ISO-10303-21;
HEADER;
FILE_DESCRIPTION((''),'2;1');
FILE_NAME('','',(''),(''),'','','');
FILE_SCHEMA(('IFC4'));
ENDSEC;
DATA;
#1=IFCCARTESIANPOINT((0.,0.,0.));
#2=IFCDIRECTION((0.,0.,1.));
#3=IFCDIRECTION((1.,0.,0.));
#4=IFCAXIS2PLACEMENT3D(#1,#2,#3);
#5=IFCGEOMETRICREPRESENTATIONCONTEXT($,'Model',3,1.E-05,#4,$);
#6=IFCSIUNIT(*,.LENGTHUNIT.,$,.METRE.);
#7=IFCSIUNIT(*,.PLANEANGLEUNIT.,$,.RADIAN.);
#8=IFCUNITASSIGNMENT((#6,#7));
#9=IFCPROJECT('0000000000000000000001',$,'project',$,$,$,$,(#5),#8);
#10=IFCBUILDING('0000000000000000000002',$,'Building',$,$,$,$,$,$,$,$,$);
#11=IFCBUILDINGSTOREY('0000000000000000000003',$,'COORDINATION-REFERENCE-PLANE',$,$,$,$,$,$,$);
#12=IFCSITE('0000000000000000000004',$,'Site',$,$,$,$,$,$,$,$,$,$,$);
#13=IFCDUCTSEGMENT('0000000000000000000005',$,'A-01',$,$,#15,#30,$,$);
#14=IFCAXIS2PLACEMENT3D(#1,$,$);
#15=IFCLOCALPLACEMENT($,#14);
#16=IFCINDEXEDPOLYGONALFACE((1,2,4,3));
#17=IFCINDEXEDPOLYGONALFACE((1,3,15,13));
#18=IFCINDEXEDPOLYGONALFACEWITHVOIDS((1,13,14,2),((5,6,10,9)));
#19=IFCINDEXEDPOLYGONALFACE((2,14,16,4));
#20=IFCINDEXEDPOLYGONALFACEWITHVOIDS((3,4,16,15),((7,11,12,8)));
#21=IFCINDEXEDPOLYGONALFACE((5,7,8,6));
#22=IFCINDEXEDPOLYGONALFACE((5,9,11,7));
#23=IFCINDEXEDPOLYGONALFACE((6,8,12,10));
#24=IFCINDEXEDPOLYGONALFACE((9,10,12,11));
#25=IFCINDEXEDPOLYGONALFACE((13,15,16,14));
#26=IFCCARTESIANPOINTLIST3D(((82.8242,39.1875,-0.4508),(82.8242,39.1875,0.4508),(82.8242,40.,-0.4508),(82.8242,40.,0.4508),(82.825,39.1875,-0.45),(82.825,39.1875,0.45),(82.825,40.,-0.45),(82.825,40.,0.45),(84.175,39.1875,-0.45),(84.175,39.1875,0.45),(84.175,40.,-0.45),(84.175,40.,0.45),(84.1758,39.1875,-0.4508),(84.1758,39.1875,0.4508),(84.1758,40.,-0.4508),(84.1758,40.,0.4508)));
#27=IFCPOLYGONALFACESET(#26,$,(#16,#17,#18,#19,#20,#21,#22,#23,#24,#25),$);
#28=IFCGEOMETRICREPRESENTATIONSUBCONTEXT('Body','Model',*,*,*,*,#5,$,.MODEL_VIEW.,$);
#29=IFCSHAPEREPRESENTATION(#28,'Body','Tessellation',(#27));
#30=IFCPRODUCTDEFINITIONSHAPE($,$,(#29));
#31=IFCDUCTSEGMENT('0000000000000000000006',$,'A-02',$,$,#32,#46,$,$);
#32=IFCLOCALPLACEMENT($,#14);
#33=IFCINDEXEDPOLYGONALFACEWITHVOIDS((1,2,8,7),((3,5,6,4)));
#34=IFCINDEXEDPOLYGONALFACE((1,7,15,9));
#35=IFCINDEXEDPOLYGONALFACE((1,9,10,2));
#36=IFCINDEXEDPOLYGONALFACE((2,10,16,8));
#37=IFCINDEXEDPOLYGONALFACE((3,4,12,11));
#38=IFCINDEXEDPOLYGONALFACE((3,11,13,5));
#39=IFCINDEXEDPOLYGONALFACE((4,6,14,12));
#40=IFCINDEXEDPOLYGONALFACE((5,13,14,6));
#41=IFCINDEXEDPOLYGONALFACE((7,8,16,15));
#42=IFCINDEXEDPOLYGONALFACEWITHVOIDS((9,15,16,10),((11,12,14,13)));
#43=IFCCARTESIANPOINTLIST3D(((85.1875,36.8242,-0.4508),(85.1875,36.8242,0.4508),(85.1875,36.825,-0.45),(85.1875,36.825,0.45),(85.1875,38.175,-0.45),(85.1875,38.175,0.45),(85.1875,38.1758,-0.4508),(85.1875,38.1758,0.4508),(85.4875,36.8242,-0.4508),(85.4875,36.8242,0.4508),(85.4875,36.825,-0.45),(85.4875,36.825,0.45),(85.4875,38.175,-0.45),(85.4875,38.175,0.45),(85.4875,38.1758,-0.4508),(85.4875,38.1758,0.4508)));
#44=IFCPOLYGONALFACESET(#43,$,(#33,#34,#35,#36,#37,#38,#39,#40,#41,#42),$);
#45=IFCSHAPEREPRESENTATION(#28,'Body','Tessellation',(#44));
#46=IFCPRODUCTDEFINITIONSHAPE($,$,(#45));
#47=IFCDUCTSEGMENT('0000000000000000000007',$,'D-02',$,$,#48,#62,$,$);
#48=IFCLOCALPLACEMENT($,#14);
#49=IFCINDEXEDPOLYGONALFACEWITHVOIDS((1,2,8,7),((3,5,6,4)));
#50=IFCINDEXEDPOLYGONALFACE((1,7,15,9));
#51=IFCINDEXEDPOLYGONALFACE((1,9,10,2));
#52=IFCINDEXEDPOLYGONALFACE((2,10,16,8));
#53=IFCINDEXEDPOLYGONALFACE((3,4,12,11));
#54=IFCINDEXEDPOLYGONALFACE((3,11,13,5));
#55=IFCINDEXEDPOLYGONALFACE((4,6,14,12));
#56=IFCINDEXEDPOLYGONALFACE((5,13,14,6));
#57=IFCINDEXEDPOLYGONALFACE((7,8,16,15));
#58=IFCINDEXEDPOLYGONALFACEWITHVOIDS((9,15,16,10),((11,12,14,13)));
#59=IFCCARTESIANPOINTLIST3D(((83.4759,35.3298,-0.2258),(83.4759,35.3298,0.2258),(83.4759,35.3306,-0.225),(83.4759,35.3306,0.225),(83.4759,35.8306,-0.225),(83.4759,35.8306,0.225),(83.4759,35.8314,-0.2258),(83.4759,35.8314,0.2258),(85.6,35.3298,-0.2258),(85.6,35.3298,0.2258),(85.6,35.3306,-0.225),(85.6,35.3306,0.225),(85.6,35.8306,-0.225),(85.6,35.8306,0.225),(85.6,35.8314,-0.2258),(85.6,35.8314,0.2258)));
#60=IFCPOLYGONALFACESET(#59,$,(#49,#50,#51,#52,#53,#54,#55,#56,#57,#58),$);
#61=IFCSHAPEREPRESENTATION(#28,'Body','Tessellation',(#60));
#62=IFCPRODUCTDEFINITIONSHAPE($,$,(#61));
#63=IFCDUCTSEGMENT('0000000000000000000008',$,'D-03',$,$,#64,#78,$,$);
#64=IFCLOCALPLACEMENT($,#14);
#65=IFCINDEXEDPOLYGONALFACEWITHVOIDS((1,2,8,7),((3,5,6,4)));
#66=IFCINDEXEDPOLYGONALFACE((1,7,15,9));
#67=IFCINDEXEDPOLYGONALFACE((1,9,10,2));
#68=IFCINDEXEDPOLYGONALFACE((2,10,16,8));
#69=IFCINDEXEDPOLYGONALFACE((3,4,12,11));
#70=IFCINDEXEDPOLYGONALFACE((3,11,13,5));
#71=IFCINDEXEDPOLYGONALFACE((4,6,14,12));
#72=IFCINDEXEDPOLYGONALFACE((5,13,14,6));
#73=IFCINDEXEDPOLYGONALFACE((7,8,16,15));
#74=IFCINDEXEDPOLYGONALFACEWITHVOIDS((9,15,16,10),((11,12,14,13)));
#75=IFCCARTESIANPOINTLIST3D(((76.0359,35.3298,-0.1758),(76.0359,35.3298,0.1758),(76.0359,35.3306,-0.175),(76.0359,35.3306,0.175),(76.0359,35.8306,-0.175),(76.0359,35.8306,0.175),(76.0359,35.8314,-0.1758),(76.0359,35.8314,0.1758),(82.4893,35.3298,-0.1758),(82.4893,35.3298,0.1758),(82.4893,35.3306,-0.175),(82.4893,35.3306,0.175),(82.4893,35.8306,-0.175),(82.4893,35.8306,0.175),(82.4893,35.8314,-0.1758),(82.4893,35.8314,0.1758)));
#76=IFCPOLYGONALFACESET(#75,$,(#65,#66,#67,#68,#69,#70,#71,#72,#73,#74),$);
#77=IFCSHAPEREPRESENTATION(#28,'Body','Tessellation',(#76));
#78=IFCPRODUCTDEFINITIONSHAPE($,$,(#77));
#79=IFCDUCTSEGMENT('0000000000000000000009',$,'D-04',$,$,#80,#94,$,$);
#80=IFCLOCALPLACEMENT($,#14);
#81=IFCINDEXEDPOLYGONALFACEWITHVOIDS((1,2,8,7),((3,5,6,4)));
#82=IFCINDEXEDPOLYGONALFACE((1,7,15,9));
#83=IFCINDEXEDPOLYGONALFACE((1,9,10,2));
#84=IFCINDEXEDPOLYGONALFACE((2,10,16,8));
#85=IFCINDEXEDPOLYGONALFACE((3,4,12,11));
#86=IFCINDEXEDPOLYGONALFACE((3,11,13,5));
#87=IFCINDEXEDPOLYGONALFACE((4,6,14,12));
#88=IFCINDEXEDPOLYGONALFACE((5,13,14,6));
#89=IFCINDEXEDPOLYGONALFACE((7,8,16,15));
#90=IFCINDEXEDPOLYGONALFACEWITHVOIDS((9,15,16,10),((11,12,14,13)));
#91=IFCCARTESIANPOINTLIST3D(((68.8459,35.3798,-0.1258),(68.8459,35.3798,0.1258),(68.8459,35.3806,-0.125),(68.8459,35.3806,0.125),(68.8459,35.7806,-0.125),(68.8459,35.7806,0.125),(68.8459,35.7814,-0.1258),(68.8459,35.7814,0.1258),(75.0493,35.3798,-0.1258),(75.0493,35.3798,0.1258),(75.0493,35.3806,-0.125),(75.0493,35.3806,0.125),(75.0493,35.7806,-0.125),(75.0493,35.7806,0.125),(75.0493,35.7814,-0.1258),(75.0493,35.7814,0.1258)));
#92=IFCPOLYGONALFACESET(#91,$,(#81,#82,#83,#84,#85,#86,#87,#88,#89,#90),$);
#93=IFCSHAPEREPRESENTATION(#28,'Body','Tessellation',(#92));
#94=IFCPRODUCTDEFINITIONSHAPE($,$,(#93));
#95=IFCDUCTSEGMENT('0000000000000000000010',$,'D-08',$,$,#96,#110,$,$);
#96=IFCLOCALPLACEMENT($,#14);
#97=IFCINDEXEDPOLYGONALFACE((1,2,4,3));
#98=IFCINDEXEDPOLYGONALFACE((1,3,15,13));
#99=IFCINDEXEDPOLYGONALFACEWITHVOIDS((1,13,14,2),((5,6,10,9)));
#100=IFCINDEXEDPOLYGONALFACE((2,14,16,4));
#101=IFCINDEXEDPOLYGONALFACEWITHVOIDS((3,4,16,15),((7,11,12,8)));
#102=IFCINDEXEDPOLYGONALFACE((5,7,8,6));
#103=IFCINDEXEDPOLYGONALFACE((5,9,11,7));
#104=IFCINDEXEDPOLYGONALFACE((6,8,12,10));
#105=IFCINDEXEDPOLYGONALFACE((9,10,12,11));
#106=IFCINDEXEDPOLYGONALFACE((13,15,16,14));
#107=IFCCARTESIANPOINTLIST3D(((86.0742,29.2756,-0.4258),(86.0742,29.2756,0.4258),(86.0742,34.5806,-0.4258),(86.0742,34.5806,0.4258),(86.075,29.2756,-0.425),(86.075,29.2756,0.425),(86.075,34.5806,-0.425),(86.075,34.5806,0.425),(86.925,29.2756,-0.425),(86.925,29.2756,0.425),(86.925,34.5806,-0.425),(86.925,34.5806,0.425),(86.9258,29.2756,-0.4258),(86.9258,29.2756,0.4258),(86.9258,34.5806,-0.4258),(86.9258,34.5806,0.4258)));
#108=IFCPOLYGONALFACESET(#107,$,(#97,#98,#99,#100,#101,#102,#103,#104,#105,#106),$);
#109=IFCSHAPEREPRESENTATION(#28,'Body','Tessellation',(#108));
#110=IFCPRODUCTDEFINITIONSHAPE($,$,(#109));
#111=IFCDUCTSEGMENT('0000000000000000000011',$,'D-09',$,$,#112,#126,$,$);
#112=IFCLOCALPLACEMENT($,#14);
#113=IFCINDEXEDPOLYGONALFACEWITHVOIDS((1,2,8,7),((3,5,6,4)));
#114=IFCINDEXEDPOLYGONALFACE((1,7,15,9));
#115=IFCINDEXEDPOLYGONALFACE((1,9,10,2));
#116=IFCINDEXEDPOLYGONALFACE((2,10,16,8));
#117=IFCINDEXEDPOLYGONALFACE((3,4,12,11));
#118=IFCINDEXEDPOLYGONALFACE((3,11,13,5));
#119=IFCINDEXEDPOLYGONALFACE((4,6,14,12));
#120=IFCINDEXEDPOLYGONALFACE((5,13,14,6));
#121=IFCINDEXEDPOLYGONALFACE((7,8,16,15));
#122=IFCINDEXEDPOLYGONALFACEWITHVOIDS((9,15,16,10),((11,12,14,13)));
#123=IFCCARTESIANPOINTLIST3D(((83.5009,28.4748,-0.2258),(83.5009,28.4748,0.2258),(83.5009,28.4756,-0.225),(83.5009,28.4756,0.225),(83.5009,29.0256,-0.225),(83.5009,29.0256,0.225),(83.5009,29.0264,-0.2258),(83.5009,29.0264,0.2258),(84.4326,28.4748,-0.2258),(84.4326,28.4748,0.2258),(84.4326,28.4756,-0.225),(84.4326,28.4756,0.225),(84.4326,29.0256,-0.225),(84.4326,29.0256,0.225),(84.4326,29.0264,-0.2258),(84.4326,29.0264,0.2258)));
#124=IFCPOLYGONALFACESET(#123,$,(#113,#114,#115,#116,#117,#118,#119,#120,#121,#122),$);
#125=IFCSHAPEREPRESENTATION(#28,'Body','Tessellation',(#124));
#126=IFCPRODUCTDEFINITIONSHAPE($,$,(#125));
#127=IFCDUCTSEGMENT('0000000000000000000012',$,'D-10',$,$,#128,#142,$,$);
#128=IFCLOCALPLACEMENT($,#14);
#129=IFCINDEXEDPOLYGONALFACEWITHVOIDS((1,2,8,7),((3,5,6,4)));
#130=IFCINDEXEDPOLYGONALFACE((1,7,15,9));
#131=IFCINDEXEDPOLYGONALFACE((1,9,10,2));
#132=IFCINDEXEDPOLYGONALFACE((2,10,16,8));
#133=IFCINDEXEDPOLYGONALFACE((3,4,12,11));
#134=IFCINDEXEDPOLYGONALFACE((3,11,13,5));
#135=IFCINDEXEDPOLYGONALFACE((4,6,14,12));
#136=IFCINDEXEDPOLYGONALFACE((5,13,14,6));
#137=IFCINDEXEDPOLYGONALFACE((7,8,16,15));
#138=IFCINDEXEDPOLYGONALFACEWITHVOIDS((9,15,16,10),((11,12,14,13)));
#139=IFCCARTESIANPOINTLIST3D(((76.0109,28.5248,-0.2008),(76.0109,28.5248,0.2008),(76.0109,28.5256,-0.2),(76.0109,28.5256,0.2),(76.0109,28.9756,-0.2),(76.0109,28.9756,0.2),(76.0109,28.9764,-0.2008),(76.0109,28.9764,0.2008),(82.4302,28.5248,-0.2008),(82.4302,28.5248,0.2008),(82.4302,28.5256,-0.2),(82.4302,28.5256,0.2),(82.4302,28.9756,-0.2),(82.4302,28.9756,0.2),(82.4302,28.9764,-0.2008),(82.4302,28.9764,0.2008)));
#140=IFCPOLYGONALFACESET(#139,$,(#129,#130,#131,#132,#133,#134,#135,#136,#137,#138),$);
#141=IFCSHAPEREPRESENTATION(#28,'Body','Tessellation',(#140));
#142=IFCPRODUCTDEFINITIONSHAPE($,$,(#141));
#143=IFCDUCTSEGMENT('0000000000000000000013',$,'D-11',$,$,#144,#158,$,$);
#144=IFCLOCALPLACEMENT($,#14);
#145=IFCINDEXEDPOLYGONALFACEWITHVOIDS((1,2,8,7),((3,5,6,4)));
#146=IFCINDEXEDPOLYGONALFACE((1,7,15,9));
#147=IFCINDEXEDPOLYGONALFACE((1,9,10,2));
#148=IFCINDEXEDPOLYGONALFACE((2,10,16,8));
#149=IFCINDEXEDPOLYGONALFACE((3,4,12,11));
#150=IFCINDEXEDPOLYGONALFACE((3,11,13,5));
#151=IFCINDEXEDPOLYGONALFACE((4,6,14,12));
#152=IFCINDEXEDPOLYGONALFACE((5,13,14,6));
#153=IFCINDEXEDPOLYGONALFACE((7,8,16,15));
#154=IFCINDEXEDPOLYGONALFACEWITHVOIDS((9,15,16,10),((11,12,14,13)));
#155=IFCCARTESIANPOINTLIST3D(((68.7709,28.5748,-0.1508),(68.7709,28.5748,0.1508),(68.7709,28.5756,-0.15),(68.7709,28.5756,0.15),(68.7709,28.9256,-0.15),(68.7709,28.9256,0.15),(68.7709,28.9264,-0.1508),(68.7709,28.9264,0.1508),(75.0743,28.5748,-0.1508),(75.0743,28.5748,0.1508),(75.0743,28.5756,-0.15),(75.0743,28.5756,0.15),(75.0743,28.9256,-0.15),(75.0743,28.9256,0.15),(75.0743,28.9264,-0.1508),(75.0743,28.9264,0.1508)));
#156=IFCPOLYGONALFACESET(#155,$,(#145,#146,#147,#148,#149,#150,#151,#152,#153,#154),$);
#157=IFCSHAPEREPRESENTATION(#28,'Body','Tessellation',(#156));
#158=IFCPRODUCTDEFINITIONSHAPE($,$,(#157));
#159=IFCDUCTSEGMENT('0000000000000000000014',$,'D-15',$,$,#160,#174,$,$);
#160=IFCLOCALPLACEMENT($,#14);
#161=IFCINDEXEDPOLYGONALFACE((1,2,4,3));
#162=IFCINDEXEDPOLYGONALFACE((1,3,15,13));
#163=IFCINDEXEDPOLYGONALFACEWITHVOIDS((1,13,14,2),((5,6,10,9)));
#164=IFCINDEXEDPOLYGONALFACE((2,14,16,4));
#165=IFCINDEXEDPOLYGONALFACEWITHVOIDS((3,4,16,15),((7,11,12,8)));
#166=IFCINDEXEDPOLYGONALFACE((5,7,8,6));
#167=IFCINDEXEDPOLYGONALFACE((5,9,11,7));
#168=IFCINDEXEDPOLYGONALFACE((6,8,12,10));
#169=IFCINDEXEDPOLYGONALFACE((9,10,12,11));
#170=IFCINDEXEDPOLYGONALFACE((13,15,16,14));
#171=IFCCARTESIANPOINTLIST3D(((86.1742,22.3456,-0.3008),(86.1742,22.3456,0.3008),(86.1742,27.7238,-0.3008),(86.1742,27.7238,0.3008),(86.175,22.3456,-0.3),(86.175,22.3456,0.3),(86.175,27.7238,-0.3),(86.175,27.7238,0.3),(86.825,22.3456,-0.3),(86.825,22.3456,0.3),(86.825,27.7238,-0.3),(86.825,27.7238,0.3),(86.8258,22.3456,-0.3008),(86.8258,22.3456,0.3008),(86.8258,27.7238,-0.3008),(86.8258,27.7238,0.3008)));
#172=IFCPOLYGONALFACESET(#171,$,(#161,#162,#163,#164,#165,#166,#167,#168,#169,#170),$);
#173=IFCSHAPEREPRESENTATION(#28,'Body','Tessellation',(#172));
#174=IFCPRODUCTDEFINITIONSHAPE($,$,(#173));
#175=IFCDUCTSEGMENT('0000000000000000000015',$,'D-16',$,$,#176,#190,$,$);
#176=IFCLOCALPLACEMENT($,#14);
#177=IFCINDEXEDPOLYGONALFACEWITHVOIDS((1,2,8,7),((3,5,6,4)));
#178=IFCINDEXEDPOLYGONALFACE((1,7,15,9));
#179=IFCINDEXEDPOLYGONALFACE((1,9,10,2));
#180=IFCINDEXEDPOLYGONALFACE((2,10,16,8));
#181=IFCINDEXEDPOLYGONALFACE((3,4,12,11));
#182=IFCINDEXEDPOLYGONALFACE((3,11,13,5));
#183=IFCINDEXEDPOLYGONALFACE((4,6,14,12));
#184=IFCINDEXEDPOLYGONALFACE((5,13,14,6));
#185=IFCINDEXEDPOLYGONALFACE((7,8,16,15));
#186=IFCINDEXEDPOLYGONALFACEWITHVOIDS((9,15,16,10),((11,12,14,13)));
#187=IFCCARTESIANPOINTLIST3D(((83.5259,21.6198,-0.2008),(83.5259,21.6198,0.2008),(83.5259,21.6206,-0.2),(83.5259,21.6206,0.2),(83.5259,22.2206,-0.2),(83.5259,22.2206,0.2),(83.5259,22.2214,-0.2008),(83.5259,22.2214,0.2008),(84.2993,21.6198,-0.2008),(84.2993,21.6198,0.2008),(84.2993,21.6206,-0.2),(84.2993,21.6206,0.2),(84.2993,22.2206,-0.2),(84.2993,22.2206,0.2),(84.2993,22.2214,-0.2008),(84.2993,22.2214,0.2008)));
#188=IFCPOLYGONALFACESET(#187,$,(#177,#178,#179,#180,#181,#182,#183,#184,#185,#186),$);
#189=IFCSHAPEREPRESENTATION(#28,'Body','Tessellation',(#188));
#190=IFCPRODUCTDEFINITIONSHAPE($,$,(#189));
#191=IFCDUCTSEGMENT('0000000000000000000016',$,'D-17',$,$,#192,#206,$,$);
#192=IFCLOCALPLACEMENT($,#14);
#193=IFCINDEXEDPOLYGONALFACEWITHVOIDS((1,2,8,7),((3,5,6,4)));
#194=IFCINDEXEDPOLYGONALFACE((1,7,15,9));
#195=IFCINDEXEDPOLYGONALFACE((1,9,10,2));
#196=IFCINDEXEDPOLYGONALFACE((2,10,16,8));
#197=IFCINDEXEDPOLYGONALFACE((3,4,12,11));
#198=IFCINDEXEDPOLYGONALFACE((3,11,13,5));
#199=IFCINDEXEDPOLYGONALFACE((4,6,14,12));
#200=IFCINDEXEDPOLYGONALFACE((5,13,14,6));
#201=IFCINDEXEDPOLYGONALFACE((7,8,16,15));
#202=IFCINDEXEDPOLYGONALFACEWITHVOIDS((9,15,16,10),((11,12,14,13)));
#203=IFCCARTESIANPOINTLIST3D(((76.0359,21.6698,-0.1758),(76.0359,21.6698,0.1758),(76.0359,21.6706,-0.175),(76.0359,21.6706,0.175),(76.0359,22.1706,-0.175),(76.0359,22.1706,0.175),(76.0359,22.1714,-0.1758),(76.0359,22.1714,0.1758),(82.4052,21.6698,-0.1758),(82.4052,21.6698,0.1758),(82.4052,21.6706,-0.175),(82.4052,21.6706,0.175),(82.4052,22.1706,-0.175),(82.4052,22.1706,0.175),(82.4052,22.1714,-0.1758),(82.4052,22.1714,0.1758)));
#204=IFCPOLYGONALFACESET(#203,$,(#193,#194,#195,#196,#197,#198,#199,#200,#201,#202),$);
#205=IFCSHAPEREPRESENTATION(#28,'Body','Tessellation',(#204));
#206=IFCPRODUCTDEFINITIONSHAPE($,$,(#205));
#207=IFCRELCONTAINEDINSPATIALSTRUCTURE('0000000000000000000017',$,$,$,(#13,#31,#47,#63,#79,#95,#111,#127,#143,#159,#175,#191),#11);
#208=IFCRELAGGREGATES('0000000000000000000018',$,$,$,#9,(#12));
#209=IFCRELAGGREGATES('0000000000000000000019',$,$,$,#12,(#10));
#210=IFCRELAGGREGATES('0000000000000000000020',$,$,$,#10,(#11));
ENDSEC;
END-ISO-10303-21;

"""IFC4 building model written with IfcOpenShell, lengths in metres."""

from ifc_helpers import new_model, si_unit, frame, origin, origin_with_axes, place, context, subcontext, project, spatial, hollow_rectangle, extrude, element, save


model = new_model("IFC4")

# Units and contexts
model_context = context("Model", 3, precision=1e-05, world=origin_with_axes())
body_context = subcontext(model_context, "Body", "Model", "MODEL_VIEW")
ifc_project = project(units=[si_unit("LENGTHUNIT", "METRE"), si_unit("PLANEANGLEUNIT", "RADIAN")], contexts=[model_context])

# Site, building, storey
site = spatial("IfcSite", under=ifc_project, Name="Site")
building = spatial("IfcBuilding", under=site, Name="Building")
storey = spatial("IfcBuildingStorey", under=building, Name="COORDINATION-REFERENCE-PLANE")

# Duct segments
duct_segment_1_placement = place(None, frame((83.5, 39.1875, 0.0), z_axis=(0.0, 1.0, 0.0), x_axis=(1.0, 0.0, 0.0)))
element("IfcDuctSegment", 1, at=duct_segment_1_placement, inside=storey, Name="A-01", context=body_context, shape_type="SweptSolid", body=[
    extrude(hollow_rectangle(XDim=1.3516, YDim=0.9016, WallThickness=0.0008), origin(), (0.0, 0.0, 1.0), 0.8125),
])
duct_segment_2_placement = place(None, frame((85.1875, 37.5, 0.0), z_axis=(1.0, 0.0, 0.0), x_axis=(0.0, 1.0, 0.0)))
element("IfcDuctSegment", 2, at=duct_segment_2_placement, inside=storey, Name="A-02", context=body_context, shape_type="SweptSolid", body=[
    extrude(hollow_rectangle(XDim=1.3516, YDim=0.9016, WallThickness=0.0008), origin(), (0.0, 0.0, 1.0), 0.3),
])
duct_segment_3_placement = place(None, frame((83.4759, 35.5806, 0.0), z_axis=(1.0, 0.0, 0.0), x_axis=(0.0, 1.0, 0.0)))
element("IfcDuctSegment", 3, at=duct_segment_3_placement, inside=storey, Name="D-02", context=body_context, shape_type="SweptSolid", body=[
    extrude(hollow_rectangle(XDim=0.5016, YDim=0.4516, WallThickness=0.0008), origin(), (0.0, 0.0, 1.0), 2.1241),
])
duct_segment_4_placement = place(None, frame((76.0359, 35.5806, 0.0), z_axis=(1.0, 0.0, 0.0), x_axis=(0.0, 1.0, 0.0)))
element("IfcDuctSegment", 4, at=duct_segment_4_placement, inside=storey, Name="D-03", context=body_context, shape_type="SweptSolid", body=[
    extrude(hollow_rectangle(XDim=0.5016, YDim=0.3516, WallThickness=0.0008), origin(), (0.0, 0.0, 1.0), 6.4534),
])
duct_segment_5_placement = place(None, frame((68.8459, 35.5806, 0.0), z_axis=(1.0, 0.0, 0.0), x_axis=(0.0, 1.0, 0.0)))
element("IfcDuctSegment", 5, at=duct_segment_5_placement, inside=storey, Name="D-04", context=body_context, shape_type="SweptSolid", body=[
    extrude(hollow_rectangle(XDim=0.4016, YDim=0.2516, WallThickness=0.0008), origin(), (0.0, 0.0, 1.0), 6.2034),
])
duct_segment_6_placement = place(None, frame((86.5, 29.2756, 0.0), z_axis=(0.0, 1.0, 0.0), x_axis=(1.0, 0.0, 0.0)))
element("IfcDuctSegment", 6, at=duct_segment_6_placement, inside=storey, Name="D-08", context=body_context, shape_type="SweptSolid", body=[
    extrude(hollow_rectangle(XDim=0.8516, YDim=0.8516, WallThickness=0.0008), origin(), (0.0, 0.0, 1.0), 5.305),
])
duct_segment_7_placement = place(None, frame((83.5009, 28.7506, 0.0), z_axis=(1.0, 0.0, 0.0), x_axis=(0.0, 1.0, 0.0)))
element("IfcDuctSegment", 7, at=duct_segment_7_placement, inside=storey, Name="D-09", context=body_context, shape_type="SweptSolid", body=[
    extrude(hollow_rectangle(XDim=0.5516, YDim=0.4516, WallThickness=0.0008), origin(), (0.0, 0.0, 1.0), 0.9316),
])
duct_segment_8_placement = place(None, frame((76.0109, 28.7506, 0.0), z_axis=(1.0, 0.0, 0.0), x_axis=(0.0, 1.0, 0.0)))
element("IfcDuctSegment", 8, at=duct_segment_8_placement, inside=storey, Name="D-10", context=body_context, shape_type="SweptSolid", body=[
    extrude(hollow_rectangle(XDim=0.4516, YDim=0.4016, WallThickness=0.0008), origin(), (0.0, 0.0, 1.0), 6.4193),
])
duct_segment_9_placement = place(None, frame((68.7709, 28.7506, 0.0), z_axis=(1.0, 0.0, 0.0), x_axis=(0.0, 1.0, 0.0)))
element("IfcDuctSegment", 9, at=duct_segment_9_placement, inside=storey, Name="D-11", context=body_context, shape_type="SweptSolid", body=[
    extrude(hollow_rectangle(XDim=0.3516, YDim=0.3016, WallThickness=0.0008), origin(), (0.0, 0.0, 1.0), 6.3034),
])
duct_segment_10_placement = place(None, frame((86.5, 22.3456, 0.0), z_axis=(0.0, 1.0, 0.0), x_axis=(1.0, 0.0, 0.0)))
element("IfcDuctSegment", 10, at=duct_segment_10_placement, inside=storey, Name="D-15", context=body_context, shape_type="SweptSolid", body=[
    extrude(hollow_rectangle(XDim=0.6516, YDim=0.6016, WallThickness=0.0008), origin(), (0.0, 0.0, 1.0), 5.3782),
])
duct_segment_11_placement = place(None, frame((83.5259, 21.9206, 0.0), z_axis=(1.0, 0.0, 0.0), x_axis=(0.0, 1.0, 0.0)))
element("IfcDuctSegment", 11, at=duct_segment_11_placement, inside=storey, Name="D-16", context=body_context, shape_type="SweptSolid", body=[
    extrude(hollow_rectangle(XDim=0.6016, YDim=0.4016, WallThickness=0.0008), origin(), (0.0, 0.0, 1.0), 0.7733),
])
duct_segment_12_placement = place(None, frame((76.0359, 21.9206, 0.0), z_axis=(1.0, 0.0, 0.0), x_axis=(0.0, 1.0, 0.0)))
element("IfcDuctSegment", 12, at=duct_segment_12_placement, inside=storey, Name="D-17", context=body_context, shape_type="SweptSolid", body=[
    extrude(hollow_rectangle(XDim=0.5016, YDim=0.3516, WallThickness=0.0008), origin(), (0.0, 0.0, 1.0), 6.3693),
])

save(model, "model.ifc")
